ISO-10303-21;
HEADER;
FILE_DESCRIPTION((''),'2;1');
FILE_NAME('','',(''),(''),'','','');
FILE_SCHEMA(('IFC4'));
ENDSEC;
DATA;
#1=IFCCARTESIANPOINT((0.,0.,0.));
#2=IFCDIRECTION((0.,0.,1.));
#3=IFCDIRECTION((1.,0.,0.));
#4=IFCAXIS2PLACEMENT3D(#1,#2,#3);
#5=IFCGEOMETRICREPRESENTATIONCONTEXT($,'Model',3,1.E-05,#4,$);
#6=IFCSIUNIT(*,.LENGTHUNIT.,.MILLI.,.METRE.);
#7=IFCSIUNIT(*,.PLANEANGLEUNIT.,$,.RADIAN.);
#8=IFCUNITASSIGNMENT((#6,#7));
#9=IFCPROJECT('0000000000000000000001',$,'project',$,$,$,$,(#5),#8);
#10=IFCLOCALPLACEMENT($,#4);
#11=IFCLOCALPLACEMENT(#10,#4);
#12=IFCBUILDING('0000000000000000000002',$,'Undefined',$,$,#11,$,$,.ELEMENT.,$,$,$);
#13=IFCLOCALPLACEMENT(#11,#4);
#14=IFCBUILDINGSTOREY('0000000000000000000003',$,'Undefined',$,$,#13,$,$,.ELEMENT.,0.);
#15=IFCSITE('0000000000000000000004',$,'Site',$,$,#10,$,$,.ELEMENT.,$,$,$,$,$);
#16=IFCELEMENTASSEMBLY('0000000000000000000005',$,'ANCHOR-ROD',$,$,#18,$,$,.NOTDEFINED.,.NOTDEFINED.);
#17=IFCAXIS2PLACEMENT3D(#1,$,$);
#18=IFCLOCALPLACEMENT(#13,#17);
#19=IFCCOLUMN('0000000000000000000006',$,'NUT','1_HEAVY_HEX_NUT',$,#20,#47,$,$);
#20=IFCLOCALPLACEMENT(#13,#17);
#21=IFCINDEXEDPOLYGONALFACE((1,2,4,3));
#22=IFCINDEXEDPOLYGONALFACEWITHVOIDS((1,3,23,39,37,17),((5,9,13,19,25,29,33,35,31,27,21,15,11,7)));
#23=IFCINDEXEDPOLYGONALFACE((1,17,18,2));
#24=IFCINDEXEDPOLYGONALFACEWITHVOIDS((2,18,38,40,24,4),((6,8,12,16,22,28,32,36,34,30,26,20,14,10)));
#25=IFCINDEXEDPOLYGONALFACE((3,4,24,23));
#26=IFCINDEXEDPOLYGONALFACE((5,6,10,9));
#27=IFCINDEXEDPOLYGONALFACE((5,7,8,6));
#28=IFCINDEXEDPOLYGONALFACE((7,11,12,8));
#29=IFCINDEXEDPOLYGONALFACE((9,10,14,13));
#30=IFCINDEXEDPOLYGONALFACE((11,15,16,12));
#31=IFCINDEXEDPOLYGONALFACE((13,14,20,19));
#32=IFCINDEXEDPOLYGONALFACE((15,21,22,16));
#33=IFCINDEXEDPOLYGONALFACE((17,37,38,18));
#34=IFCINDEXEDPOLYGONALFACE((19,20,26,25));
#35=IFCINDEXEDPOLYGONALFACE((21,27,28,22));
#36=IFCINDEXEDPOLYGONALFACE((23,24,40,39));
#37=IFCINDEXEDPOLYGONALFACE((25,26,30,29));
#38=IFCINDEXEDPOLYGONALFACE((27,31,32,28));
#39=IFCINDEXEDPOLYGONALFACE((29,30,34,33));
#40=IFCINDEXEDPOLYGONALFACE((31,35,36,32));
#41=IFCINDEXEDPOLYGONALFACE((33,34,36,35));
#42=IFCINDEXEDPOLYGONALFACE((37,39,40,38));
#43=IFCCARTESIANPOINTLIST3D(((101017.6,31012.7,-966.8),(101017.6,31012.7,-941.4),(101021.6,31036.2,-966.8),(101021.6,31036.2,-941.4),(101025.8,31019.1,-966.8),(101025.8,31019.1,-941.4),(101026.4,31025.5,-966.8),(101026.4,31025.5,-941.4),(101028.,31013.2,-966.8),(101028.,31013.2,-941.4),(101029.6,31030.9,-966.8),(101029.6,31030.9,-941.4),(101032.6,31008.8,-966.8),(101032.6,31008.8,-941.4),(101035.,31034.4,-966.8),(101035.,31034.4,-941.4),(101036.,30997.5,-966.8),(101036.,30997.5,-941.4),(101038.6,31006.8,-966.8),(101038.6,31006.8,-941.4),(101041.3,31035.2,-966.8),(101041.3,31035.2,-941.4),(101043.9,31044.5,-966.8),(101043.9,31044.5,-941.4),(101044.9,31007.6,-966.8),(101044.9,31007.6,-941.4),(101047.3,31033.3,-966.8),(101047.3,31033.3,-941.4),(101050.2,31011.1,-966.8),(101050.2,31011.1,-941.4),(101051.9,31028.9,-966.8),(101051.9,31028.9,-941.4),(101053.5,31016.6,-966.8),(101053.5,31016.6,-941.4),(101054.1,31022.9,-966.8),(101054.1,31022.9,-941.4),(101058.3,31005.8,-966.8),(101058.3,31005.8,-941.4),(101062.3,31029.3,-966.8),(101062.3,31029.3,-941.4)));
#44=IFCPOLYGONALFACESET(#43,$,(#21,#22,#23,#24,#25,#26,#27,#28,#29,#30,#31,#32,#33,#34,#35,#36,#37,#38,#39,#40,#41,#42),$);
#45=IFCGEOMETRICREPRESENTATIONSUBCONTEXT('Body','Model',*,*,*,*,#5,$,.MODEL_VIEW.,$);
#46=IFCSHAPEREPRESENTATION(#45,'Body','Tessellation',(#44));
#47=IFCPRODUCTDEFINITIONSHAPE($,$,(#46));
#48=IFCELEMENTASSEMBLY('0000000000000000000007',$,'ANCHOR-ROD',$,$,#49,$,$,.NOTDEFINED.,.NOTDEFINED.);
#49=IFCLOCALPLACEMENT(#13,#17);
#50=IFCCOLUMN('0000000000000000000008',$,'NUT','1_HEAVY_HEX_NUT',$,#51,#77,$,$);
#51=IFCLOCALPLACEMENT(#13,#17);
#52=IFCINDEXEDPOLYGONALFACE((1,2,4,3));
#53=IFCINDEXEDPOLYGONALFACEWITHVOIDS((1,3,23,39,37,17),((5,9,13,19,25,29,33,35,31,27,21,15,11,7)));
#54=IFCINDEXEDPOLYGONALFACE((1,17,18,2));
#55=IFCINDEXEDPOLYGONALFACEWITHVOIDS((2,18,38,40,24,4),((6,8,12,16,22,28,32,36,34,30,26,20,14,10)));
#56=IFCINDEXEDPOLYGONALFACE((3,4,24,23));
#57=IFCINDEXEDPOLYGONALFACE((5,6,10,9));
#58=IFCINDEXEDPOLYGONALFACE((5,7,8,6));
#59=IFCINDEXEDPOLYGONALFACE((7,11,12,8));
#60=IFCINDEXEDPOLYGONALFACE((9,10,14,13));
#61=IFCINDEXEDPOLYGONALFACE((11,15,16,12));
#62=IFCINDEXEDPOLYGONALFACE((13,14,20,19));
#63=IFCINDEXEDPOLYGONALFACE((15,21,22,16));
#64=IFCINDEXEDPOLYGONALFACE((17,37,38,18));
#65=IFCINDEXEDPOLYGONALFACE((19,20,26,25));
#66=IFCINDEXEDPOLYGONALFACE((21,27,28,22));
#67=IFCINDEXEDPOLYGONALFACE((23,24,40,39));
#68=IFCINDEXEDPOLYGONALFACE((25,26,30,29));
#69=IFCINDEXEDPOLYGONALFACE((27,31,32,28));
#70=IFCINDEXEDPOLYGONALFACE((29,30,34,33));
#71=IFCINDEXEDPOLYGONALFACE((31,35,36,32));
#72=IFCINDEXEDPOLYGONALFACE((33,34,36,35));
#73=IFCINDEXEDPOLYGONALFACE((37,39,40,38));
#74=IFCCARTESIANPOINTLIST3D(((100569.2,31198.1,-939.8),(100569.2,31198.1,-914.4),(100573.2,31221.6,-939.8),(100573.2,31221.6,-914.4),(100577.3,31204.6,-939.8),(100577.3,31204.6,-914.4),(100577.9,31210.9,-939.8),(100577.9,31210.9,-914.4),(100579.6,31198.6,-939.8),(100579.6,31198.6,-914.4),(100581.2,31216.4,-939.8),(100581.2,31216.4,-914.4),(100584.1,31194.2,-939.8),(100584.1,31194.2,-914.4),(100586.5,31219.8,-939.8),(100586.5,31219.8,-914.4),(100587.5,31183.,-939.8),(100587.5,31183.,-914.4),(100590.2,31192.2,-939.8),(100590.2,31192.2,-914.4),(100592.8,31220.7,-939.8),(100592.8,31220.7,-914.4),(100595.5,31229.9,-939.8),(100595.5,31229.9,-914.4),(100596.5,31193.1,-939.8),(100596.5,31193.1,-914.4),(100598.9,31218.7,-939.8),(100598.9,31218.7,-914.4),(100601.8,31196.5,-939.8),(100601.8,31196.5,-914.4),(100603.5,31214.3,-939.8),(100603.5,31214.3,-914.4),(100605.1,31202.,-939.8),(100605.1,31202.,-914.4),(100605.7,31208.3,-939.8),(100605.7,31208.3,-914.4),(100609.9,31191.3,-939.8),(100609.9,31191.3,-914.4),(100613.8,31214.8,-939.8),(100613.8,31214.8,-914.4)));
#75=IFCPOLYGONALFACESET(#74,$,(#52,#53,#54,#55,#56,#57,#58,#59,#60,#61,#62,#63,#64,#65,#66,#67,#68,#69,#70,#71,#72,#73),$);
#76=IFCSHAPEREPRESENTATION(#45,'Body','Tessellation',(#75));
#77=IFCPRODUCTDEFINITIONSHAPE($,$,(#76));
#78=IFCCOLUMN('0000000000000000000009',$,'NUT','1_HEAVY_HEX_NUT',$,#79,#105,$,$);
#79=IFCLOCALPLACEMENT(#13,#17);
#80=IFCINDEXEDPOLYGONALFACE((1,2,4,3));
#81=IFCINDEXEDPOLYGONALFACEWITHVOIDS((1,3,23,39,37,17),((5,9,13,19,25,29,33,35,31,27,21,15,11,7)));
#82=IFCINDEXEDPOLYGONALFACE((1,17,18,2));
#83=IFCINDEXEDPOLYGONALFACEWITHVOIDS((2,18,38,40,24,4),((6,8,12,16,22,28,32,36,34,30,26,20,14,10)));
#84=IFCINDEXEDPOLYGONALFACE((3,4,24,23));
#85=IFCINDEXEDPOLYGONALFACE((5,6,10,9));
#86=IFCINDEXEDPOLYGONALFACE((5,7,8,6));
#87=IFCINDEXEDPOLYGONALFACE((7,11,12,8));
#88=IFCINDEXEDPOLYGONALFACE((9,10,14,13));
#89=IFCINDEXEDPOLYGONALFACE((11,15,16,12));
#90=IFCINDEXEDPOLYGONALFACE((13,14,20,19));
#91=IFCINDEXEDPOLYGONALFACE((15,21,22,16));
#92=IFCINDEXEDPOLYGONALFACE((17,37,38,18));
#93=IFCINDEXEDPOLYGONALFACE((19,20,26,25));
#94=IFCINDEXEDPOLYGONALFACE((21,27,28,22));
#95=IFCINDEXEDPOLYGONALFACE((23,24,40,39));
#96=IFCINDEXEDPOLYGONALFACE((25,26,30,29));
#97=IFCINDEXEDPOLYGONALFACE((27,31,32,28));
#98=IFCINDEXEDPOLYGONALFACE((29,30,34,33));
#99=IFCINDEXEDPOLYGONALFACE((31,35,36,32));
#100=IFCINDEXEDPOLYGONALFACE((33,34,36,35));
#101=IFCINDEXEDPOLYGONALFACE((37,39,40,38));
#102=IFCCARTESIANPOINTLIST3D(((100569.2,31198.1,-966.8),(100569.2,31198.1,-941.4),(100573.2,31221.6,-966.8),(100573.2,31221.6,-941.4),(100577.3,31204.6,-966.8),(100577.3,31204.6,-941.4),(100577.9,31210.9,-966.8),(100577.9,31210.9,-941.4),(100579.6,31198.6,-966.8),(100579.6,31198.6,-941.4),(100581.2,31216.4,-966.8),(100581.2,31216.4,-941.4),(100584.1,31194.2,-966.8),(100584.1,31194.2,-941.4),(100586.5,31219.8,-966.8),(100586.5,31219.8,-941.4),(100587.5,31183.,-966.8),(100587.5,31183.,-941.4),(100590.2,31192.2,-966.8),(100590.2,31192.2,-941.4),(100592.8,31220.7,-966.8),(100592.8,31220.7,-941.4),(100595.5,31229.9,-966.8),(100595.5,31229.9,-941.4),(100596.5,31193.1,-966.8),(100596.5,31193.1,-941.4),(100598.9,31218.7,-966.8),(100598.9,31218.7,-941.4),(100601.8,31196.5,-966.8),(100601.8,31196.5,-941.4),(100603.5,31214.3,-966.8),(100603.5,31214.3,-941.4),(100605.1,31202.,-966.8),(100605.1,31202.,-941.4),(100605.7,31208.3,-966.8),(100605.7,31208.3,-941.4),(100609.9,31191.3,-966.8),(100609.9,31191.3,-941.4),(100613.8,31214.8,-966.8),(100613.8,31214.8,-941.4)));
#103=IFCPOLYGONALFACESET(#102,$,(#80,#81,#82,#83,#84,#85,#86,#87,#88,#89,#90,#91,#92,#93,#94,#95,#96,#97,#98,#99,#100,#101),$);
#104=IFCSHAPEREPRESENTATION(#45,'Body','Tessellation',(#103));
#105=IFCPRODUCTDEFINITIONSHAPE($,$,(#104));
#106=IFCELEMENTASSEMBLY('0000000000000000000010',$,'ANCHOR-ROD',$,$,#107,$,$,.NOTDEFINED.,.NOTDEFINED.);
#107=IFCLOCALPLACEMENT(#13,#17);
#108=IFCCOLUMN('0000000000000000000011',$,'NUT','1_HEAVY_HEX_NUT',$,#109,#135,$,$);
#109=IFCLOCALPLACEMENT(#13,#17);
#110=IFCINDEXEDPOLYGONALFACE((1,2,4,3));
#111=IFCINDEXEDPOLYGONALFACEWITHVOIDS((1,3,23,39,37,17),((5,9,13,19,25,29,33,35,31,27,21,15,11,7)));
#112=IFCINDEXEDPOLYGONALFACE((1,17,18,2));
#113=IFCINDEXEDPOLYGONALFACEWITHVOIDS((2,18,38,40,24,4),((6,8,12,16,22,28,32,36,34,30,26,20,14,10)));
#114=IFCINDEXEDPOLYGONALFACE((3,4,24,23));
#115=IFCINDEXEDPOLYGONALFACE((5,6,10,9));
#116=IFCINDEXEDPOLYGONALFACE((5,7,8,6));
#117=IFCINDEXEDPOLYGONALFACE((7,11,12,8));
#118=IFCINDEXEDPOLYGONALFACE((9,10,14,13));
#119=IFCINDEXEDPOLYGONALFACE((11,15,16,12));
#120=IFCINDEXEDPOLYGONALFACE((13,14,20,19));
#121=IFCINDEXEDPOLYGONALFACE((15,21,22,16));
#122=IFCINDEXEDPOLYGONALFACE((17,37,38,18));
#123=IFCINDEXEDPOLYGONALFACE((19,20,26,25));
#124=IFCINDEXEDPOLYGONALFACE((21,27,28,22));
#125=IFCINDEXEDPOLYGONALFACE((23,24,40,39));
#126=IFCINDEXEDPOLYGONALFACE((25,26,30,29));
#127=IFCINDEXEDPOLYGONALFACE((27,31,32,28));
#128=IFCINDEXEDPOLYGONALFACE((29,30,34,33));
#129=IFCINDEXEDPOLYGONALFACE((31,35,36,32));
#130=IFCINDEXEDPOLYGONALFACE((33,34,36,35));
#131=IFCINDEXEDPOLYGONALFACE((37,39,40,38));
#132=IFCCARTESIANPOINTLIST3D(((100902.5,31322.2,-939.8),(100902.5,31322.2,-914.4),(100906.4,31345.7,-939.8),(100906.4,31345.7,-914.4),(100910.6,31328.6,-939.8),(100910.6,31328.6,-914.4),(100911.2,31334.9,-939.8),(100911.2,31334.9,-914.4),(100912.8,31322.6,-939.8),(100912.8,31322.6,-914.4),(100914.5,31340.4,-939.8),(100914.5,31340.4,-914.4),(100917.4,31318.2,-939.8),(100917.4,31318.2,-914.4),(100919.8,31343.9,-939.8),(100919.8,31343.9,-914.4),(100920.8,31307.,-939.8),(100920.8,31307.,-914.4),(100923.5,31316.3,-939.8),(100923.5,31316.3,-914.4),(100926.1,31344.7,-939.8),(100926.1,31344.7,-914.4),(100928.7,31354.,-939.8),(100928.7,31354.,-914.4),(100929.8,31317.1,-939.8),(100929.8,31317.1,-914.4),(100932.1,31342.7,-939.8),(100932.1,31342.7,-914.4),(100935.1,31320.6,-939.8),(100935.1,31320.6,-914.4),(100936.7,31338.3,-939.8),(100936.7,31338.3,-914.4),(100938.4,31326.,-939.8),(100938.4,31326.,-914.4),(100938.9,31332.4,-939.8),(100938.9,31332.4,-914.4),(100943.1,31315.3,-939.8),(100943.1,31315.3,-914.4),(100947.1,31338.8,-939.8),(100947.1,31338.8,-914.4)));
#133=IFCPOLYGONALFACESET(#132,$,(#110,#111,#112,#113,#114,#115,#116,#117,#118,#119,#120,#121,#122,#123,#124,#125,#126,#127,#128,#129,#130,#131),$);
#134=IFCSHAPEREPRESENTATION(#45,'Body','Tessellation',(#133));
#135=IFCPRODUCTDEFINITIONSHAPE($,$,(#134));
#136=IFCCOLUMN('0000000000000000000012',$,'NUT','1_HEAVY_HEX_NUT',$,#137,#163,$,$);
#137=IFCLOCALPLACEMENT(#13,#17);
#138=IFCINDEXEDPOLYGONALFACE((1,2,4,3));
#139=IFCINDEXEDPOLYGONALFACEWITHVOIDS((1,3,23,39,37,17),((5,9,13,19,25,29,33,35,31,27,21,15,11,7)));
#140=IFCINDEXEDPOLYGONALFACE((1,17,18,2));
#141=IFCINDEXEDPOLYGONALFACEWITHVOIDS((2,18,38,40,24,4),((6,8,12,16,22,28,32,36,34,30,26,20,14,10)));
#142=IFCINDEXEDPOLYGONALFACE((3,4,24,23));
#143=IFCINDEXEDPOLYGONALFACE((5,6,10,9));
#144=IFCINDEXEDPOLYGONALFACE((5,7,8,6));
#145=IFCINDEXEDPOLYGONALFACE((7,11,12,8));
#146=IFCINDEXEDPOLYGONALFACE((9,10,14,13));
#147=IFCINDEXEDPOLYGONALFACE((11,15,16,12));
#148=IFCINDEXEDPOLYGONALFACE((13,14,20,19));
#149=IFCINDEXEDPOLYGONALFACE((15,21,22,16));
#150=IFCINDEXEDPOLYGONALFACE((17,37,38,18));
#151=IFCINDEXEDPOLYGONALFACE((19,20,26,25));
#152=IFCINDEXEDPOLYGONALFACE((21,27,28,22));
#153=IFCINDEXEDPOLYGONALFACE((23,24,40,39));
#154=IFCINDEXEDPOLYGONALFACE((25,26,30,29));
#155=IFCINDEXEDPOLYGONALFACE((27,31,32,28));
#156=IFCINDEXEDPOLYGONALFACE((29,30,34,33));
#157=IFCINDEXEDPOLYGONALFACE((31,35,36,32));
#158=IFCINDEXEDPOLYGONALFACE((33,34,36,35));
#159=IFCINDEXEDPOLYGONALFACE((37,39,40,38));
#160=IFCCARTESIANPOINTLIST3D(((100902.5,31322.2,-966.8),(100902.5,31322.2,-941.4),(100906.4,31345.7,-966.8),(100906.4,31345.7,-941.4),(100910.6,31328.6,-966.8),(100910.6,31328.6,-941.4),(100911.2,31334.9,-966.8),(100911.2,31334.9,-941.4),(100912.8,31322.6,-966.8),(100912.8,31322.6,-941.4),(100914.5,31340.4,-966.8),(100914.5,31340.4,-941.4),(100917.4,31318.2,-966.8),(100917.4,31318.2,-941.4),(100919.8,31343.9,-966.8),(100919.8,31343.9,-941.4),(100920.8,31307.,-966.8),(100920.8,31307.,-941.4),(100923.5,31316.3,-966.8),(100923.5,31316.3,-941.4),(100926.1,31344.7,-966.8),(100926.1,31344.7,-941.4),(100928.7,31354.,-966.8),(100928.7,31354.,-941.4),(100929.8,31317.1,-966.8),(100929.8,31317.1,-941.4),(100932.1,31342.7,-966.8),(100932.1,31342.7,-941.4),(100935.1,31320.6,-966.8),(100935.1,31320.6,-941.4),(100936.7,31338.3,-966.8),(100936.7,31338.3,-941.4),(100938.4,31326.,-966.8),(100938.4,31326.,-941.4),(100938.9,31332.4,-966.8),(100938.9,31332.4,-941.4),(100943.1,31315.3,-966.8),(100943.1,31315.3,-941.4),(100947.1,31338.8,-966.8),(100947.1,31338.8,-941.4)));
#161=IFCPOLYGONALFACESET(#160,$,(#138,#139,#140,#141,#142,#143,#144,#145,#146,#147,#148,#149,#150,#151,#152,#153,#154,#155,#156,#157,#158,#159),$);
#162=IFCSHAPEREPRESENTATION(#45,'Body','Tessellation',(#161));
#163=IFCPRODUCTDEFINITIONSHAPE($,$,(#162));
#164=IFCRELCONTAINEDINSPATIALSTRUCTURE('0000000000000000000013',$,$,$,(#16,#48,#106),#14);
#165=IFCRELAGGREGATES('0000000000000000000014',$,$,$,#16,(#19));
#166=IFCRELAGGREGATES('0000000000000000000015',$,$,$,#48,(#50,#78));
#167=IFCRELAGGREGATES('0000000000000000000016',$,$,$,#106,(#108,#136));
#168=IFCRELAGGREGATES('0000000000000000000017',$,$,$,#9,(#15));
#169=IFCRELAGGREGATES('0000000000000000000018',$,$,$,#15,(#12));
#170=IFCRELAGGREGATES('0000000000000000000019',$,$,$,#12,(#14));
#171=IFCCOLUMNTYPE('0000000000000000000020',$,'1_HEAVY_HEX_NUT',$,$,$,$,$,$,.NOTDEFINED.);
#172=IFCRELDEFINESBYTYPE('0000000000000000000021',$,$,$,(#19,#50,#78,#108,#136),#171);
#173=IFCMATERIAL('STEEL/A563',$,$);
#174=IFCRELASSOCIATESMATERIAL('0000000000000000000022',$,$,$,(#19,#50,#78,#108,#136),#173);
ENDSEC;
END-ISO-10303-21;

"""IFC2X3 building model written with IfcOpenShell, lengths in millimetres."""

from ifc_helpers import new_model, si_unit, frame, origin_with_axes, place, context, subcontext, project, spatial, polyline, outline, extrude, material, type_object, element, aggregate, save


model = new_model("IFC2X3")

# Units and contexts
model_context = context("Model", 3, precision=1e-05, world=origin_with_axes())
body_context = subcontext(model_context, "Body", "Model", "MODEL_VIEW")
ifc_project = project(units=[si_unit("LENGTHUNIT", "METRE", prefix="MILLI"), si_unit("PLANEANGLEUNIT", "RADIAN")], contexts=[model_context])

# Site, building, storey
site_placement = place(None, origin_with_axes())
site = spatial("IfcSite", under=ifc_project, at=site_placement, Name="Site", CompositionType="ELEMENT")
building_placement = place(site_placement, origin_with_axes())
building = spatial("IfcBuilding", under=site, at=building_placement, Name="Undefined", CompositionType="ELEMENT")
storey_placement = place(building_placement, origin_with_axes())
storey = spatial("IfcBuildingStorey", under=building, at=storey_placement, Name="Undefined", CompositionType="ELEMENT", Elevation=0.0)

# Element assemblies, columns
ifc_material_1 = material(Name="STEEL/A563")
column_type_1 = type_object("IfcColumnType", Name="1_HEAVY_HEX_NUT", PredefinedType="NOTDEFINED")
assembly_1_placement = place(storey_placement, origin_with_axes())
assembly_1 = element("IfcElementAssembly", 1, at=assembly_1_placement, inside=storey, Name="ANCHOR-ROD", AssemblyPlace="NOTDEFINED", PredefinedType="NOTDEFINED")
column_1_placement = place(assembly_1_placement, frame((101039.9, 31021.0, -941.4), z_axis=(0.0, 0.0, -1.0), x_axis=(-0.34879, 0.937201, 0.0)))
column_1 = element("IfcColumn", 2, at=column_1_placement, type_object=column_type_1, material=ifc_material_1, Name="NUT", Description="1_HEAVY_HEX_NUT", context=body_context, shape_type="SweptSolid", body=[
    extrude(outline(polyline([(-11.9, -20.6), (-23.8, 0.0), (-11.9, 20.6), (11.9, 20.6), (23.8, 0.0), (11.9, -20.6), (-11.9, -20.6)]), holes=[polyline([(11.2, 8.9), (6.2, 12.9), (0.0, 14.3), (-6.2, 12.9), (-11.2, 8.9), (-13.9, 3.2), (-13.9, -3.2), (-11.2, -8.9), (-6.2, -12.9), (0.0, -14.3), (6.2, -12.9), (11.2, -8.9), (13.9, -3.2), (13.9, 3.2), (11.2, 8.9)])]), frame((0.0, 0.0, 25.4), z_axis=(0.0, 0.0, -1.0), x_axis=(0.0, 1.0, 0.0)), (0.0, 0.0, 1.0), 25.4),
])
aggregate(assembly_1, [column_1])
assembly_2_placement = place(storey_placement, origin_with_axes())
assembly_2 = element("IfcElementAssembly", 3, at=assembly_2_placement, inside=storey, Name="ANCHOR-ROD", AssemblyPlace="NOTDEFINED", PredefinedType="NOTDEFINED")
column_2_placement = place(assembly_2_placement, frame((100591.5, 31206.5, -914.4), z_axis=(0.0, 0.0, -1.0), x_axis=(0.34879, -0.937201, 0.0)))
column_2 = element("IfcColumn", 4, at=column_2_placement, type_object=column_type_1, material=ifc_material_1, Name="NUT", Description="1_HEAVY_HEX_NUT", context=body_context, shape_type="SweptSolid", body=[
    extrude(outline(polyline([(-11.9, -20.6), (-23.8, 0.0), (-11.9, 20.6), (11.9, 20.6), (23.8, 0.0), (11.9, -20.6), (-11.9, -20.6)]), holes=[polyline([(11.2, 8.9), (6.2, 12.9), (0.0, 14.3), (-6.2, 12.9), (-11.2, 8.9), (-13.9, 3.2), (-13.9, -3.2), (-11.2, -8.9), (-6.2, -12.9), (0.0, -14.3), (6.2, -12.9), (11.2, -8.9), (13.9, -3.2), (13.9, 3.2), (11.2, 8.9)])]), frame((0.0, 0.0, 25.4), z_axis=(0.0, 0.0, -1.0), x_axis=(0.0, 1.0, 0.0)), (0.0, 0.0, 1.0), 25.4),
])
column_3_placement = place(assembly_2_placement, frame((100591.5, 31206.5, -941.4), z_axis=(0.0, 0.0, -1.0), x_axis=(0.34879, -0.937201, 0.0)))
column_3 = element("IfcColumn", 5, at=column_3_placement, type_object=column_type_1, material=ifc_material_1, Name="NUT", Description="1_HEAVY_HEX_NUT", context=body_context, shape_type="SweptSolid", body=[
    extrude(outline(polyline([(-11.9, -20.6), (-23.8, 0.0), (-11.9, 20.6), (11.9, 20.6), (23.8, 0.0), (11.9, -20.6), (-11.9, -20.6)]), holes=[polyline([(11.2, 8.9), (6.2, 12.9), (0.0, 14.3), (-6.2, 12.9), (-11.2, 8.9), (-13.9, 3.2), (-13.9, -3.2), (-11.2, -8.9), (-6.2, -12.9), (0.0, -14.3), (6.2, -12.9), (11.2, -8.9), (13.9, -3.2), (13.9, 3.2), (11.2, 8.9)])]), frame((0.0, 0.0, 25.4), z_axis=(0.0, 0.0, -1.0), x_axis=(0.0, 1.0, 0.0)), (0.0, 0.0, 1.0), 25.4),
])
aggregate(assembly_2, [column_2, column_3])
assembly_3_placement = place(storey_placement, origin_with_axes())
assembly_3 = element("IfcElementAssembly", 6, at=assembly_3_placement, inside=storey, Name="ANCHOR-ROD", AssemblyPlace="NOTDEFINED", PredefinedType="NOTDEFINED")
column_4_placement = place(assembly_3_placement, frame((100924.8, 31330.5, -914.4), z_axis=(0.0, 0.0, -1.0), x_axis=(-0.34879, 0.937201, 0.0)))
column_4 = element("IfcColumn", 7, at=column_4_placement, type_object=column_type_1, material=ifc_material_1, Name="NUT", Description="1_HEAVY_HEX_NUT", context=body_context, shape_type="SweptSolid", body=[
    extrude(outline(polyline([(-11.9, -20.6), (-23.8, 0.0), (-11.9, 20.6), (11.9, 20.6), (23.8, 0.0), (11.9, -20.6), (-11.9, -20.6)]), holes=[polyline([(11.2, 8.9), (6.2, 12.9), (0.0, 14.3), (-6.2, 12.9), (-11.2, 8.9), (-13.9, 3.2), (-13.9, -3.2), (-11.2, -8.9), (-6.2, -12.9), (0.0, -14.3), (6.2, -12.9), (11.2, -8.9), (13.9, -3.2), (13.9, 3.2), (11.2, 8.9)])]), frame((0.0, 0.0, 25.4), z_axis=(0.0, 0.0, -1.0), x_axis=(0.0, 1.0, 0.0)), (0.0, 0.0, 1.0), 25.4),
])
column_5_placement = place(assembly_3_placement, frame((100924.8, 31330.5, -941.4), z_axis=(0.0, 0.0, -1.0), x_axis=(-0.34879, 0.937201, 0.0)))
column_5 = element("IfcColumn", 8, at=column_5_placement, type_object=column_type_1, material=ifc_material_1, Name="NUT", Description="1_HEAVY_HEX_NUT", context=body_context, shape_type="SweptSolid", body=[
    extrude(outline(polyline([(-11.9, -20.6), (-23.8, 0.0), (-11.9, 20.6), (11.9, 20.6), (23.8, 0.0), (11.9, -20.6), (-11.9, -20.6)]), holes=[polyline([(11.2, 8.9), (6.2, 12.9), (0.0, 14.3), (-6.2, 12.9), (-11.2, 8.9), (-13.9, 3.2), (-13.9, -3.2), (-11.2, -8.9), (-6.2, -12.9), (0.0, -14.3), (6.2, -12.9), (11.2, -8.9), (13.9, -3.2), (13.9, 3.2), (11.2, 8.9)])]), frame((0.0, 0.0, 25.4), z_axis=(0.0, 0.0, -1.0), x_axis=(0.0, 1.0, 0.0)), (0.0, 0.0, 1.0), 25.4),
])
aggregate(assembly_3, [column_4, column_5])

save(model, "model.ifc")
